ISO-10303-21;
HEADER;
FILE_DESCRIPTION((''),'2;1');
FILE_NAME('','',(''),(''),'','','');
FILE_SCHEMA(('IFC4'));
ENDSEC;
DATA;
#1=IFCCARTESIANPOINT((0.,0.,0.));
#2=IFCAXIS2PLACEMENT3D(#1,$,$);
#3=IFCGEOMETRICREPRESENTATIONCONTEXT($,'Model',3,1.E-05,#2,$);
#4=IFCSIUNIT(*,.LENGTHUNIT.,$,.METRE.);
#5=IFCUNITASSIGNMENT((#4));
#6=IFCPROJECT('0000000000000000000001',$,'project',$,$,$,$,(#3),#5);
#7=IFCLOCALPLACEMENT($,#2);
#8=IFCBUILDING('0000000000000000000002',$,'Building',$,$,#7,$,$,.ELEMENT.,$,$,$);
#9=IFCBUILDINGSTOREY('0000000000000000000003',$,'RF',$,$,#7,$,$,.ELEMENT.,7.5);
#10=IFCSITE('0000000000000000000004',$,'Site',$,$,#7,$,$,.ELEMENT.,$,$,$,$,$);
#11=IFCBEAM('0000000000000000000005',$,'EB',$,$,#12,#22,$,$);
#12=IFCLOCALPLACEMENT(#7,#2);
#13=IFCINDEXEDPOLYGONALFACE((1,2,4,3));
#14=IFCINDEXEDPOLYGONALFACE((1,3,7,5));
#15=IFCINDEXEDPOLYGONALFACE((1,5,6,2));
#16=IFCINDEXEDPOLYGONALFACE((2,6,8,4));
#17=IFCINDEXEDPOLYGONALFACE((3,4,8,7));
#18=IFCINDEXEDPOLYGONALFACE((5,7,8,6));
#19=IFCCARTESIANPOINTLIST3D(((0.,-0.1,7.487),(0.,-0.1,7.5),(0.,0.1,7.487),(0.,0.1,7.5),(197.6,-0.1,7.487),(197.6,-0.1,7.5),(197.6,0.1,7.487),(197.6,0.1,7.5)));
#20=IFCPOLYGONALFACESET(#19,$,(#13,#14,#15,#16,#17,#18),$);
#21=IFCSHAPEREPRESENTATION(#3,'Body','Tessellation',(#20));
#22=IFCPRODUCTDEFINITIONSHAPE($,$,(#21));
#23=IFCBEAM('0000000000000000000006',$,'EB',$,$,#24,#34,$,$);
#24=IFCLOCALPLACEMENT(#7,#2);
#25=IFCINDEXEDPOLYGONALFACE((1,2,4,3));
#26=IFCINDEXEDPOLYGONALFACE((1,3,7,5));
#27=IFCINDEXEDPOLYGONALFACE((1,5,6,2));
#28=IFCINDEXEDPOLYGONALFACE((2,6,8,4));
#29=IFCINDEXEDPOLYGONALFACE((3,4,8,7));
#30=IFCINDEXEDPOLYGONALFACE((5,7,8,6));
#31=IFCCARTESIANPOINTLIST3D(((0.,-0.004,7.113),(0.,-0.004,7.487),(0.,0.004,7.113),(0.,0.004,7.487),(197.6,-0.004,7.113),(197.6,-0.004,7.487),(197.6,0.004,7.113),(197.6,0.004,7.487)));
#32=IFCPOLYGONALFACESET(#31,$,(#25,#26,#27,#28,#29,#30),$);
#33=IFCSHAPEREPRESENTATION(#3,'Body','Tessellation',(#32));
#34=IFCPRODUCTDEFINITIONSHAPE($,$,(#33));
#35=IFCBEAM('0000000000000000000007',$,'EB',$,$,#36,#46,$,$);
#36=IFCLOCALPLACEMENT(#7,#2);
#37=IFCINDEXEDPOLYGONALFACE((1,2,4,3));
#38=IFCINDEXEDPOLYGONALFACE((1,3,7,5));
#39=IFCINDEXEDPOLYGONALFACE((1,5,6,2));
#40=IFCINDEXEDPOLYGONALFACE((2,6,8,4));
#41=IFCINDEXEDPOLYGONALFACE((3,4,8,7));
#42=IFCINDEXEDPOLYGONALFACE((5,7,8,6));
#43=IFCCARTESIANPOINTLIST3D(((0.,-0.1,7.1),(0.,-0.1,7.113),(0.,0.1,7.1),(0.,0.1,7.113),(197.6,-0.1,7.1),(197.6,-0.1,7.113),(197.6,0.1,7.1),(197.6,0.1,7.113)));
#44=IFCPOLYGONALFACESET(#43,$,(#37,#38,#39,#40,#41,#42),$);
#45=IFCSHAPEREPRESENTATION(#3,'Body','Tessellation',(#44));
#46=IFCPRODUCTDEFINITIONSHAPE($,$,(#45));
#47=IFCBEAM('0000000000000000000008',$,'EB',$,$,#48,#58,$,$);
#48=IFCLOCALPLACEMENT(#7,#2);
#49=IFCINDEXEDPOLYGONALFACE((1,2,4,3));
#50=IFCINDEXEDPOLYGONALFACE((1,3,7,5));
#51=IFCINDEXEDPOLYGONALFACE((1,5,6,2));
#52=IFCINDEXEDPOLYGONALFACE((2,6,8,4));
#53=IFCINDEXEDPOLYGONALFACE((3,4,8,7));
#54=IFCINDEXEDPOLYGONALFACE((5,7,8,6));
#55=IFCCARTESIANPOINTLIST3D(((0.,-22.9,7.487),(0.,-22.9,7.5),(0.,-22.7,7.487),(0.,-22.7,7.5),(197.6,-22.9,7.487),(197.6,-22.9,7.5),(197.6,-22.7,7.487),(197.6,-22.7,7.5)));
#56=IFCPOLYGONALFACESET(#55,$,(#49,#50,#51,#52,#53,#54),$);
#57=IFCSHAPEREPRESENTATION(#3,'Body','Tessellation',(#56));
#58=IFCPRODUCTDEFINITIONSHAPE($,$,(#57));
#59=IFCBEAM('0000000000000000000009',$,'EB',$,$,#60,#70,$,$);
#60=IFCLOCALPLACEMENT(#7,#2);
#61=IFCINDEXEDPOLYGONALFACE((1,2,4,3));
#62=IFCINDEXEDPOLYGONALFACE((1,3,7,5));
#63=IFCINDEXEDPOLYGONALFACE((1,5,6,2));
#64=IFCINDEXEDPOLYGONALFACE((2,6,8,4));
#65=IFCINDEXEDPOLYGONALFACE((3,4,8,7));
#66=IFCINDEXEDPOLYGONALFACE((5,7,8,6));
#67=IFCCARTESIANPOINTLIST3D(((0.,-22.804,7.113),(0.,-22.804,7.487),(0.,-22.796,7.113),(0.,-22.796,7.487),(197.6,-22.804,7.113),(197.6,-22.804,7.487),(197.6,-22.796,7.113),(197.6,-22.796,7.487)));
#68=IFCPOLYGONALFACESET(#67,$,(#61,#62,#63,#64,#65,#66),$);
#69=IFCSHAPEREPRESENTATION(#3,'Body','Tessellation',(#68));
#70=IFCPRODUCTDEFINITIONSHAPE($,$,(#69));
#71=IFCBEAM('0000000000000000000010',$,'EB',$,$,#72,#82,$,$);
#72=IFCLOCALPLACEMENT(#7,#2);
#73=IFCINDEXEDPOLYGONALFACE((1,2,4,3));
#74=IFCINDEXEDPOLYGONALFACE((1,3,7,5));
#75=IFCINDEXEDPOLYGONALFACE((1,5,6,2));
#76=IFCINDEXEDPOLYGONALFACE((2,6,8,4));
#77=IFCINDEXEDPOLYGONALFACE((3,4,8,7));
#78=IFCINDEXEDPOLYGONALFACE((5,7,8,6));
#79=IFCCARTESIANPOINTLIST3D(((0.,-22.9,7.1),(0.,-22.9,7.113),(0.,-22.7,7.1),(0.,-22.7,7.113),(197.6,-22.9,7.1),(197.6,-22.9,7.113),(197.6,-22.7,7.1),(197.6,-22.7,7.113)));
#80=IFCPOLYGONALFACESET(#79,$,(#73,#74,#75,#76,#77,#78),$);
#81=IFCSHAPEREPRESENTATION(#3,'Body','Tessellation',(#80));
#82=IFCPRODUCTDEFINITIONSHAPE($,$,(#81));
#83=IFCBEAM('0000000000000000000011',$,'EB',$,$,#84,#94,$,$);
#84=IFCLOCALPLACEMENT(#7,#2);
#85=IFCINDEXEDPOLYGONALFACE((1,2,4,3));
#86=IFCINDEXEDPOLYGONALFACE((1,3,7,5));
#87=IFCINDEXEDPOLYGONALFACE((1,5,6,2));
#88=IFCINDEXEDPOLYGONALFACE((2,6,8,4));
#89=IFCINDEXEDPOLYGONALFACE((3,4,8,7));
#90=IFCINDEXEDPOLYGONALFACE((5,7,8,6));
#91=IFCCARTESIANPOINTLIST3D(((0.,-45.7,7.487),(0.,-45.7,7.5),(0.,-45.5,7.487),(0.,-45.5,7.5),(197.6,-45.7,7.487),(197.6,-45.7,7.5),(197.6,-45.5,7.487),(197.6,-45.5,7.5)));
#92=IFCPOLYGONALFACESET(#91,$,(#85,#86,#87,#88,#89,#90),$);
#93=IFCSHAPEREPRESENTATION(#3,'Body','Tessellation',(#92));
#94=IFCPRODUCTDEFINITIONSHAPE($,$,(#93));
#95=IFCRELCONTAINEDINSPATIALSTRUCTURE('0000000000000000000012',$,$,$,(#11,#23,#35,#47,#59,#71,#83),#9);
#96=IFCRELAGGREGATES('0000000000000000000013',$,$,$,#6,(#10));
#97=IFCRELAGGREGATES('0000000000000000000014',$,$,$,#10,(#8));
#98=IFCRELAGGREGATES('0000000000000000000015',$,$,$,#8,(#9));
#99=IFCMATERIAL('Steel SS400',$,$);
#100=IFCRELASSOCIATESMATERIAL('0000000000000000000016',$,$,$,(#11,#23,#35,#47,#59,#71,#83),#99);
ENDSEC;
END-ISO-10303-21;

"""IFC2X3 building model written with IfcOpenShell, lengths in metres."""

from ifc_helpers import new_model, si_unit, frame, origin, origin_2d, place, context, project, spatial, rectangle, extrude, material, element, save


model = new_model("IFC2X3")

# Units and contexts
model_context = context("Model", 3, precision=1e-05, world=origin())
ifc_project = project(units=[si_unit("LENGTHUNIT", "METRE")], contexts=[model_context])

# Site, building, storey
placement = place(None, origin())
site = spatial("IfcSite", under=ifc_project, at=placement, Name="Site", CompositionType="ELEMENT")
building = spatial("IfcBuilding", under=site, at=placement, Name="Building", CompositionType="ELEMENT")
storey = spatial("IfcBuildingStorey", under=building, at=placement, Name="RF", CompositionType="ELEMENT", Elevation=7.5)

# Beams
ifc_material = material(Name="Steel SS400")
beam_1_placement = place(None, frame((98.8, 0.0, 7.487)))
element("IfcBeam", 1, at=beam_1_placement, inside=storey, material=ifc_material, Name="EB", context=model_context, shape_type="SweptSolid", body=[
    extrude(rectangle(XDim=197.6, YDim=0.2, at=origin_2d()), origin(), (0.0, 0.0, 1.0), 0.013),
])
beam_2_placement = place(None, frame((98.8, 0.0, 7.113)))
element("IfcBeam", 2, at=beam_2_placement, inside=storey, material=ifc_material, Name="EB", context=model_context, shape_type="SweptSolid", body=[
    extrude(rectangle(XDim=197.6, YDim=0.008, at=origin_2d()), origin(), (0.0, 0.0, 1.0), 0.374),
])
for number, where, name in (
    (3, (98.8, 0.0, 7.1), "EB"),
    (4, (98.8, -22.8, 7.487), "EB"),
):
    element("IfcBeam", number, at=place(None, frame(where)), inside=storey, material=ifc_material, Name=name, context=model_context, shape_type="SweptSolid", body=[
        extrude(rectangle(XDim=197.6, YDim=0.2, at=origin_2d()), origin(), (0.0, 0.0, 1.0), 0.013),
    ])
beam_3_placement = place(None, frame((98.8, -22.8, 7.113)))
element("IfcBeam", 5, at=beam_3_placement, inside=storey, material=ifc_material, Name="EB", context=model_context, shape_type="SweptSolid", body=[
    extrude(rectangle(XDim=197.6, YDim=0.008, at=origin_2d()), origin(), (0.0, 0.0, 1.0), 0.374),
])
for number, where, name in (
    (6, (98.8, -22.8, 7.1), "EB"),
    (7, (98.8, -45.6, 7.487), "EB"),
):
    element("IfcBeam", number, at=place(None, frame(where)), inside=storey, material=ifc_material, Name=name, context=model_context, shape_type="SweptSolid", body=[
        extrude(rectangle(XDim=197.6, YDim=0.2, at=origin_2d()), origin(), (0.0, 0.0, 1.0), 0.013),
    ])

save(model, "model.ifc")
